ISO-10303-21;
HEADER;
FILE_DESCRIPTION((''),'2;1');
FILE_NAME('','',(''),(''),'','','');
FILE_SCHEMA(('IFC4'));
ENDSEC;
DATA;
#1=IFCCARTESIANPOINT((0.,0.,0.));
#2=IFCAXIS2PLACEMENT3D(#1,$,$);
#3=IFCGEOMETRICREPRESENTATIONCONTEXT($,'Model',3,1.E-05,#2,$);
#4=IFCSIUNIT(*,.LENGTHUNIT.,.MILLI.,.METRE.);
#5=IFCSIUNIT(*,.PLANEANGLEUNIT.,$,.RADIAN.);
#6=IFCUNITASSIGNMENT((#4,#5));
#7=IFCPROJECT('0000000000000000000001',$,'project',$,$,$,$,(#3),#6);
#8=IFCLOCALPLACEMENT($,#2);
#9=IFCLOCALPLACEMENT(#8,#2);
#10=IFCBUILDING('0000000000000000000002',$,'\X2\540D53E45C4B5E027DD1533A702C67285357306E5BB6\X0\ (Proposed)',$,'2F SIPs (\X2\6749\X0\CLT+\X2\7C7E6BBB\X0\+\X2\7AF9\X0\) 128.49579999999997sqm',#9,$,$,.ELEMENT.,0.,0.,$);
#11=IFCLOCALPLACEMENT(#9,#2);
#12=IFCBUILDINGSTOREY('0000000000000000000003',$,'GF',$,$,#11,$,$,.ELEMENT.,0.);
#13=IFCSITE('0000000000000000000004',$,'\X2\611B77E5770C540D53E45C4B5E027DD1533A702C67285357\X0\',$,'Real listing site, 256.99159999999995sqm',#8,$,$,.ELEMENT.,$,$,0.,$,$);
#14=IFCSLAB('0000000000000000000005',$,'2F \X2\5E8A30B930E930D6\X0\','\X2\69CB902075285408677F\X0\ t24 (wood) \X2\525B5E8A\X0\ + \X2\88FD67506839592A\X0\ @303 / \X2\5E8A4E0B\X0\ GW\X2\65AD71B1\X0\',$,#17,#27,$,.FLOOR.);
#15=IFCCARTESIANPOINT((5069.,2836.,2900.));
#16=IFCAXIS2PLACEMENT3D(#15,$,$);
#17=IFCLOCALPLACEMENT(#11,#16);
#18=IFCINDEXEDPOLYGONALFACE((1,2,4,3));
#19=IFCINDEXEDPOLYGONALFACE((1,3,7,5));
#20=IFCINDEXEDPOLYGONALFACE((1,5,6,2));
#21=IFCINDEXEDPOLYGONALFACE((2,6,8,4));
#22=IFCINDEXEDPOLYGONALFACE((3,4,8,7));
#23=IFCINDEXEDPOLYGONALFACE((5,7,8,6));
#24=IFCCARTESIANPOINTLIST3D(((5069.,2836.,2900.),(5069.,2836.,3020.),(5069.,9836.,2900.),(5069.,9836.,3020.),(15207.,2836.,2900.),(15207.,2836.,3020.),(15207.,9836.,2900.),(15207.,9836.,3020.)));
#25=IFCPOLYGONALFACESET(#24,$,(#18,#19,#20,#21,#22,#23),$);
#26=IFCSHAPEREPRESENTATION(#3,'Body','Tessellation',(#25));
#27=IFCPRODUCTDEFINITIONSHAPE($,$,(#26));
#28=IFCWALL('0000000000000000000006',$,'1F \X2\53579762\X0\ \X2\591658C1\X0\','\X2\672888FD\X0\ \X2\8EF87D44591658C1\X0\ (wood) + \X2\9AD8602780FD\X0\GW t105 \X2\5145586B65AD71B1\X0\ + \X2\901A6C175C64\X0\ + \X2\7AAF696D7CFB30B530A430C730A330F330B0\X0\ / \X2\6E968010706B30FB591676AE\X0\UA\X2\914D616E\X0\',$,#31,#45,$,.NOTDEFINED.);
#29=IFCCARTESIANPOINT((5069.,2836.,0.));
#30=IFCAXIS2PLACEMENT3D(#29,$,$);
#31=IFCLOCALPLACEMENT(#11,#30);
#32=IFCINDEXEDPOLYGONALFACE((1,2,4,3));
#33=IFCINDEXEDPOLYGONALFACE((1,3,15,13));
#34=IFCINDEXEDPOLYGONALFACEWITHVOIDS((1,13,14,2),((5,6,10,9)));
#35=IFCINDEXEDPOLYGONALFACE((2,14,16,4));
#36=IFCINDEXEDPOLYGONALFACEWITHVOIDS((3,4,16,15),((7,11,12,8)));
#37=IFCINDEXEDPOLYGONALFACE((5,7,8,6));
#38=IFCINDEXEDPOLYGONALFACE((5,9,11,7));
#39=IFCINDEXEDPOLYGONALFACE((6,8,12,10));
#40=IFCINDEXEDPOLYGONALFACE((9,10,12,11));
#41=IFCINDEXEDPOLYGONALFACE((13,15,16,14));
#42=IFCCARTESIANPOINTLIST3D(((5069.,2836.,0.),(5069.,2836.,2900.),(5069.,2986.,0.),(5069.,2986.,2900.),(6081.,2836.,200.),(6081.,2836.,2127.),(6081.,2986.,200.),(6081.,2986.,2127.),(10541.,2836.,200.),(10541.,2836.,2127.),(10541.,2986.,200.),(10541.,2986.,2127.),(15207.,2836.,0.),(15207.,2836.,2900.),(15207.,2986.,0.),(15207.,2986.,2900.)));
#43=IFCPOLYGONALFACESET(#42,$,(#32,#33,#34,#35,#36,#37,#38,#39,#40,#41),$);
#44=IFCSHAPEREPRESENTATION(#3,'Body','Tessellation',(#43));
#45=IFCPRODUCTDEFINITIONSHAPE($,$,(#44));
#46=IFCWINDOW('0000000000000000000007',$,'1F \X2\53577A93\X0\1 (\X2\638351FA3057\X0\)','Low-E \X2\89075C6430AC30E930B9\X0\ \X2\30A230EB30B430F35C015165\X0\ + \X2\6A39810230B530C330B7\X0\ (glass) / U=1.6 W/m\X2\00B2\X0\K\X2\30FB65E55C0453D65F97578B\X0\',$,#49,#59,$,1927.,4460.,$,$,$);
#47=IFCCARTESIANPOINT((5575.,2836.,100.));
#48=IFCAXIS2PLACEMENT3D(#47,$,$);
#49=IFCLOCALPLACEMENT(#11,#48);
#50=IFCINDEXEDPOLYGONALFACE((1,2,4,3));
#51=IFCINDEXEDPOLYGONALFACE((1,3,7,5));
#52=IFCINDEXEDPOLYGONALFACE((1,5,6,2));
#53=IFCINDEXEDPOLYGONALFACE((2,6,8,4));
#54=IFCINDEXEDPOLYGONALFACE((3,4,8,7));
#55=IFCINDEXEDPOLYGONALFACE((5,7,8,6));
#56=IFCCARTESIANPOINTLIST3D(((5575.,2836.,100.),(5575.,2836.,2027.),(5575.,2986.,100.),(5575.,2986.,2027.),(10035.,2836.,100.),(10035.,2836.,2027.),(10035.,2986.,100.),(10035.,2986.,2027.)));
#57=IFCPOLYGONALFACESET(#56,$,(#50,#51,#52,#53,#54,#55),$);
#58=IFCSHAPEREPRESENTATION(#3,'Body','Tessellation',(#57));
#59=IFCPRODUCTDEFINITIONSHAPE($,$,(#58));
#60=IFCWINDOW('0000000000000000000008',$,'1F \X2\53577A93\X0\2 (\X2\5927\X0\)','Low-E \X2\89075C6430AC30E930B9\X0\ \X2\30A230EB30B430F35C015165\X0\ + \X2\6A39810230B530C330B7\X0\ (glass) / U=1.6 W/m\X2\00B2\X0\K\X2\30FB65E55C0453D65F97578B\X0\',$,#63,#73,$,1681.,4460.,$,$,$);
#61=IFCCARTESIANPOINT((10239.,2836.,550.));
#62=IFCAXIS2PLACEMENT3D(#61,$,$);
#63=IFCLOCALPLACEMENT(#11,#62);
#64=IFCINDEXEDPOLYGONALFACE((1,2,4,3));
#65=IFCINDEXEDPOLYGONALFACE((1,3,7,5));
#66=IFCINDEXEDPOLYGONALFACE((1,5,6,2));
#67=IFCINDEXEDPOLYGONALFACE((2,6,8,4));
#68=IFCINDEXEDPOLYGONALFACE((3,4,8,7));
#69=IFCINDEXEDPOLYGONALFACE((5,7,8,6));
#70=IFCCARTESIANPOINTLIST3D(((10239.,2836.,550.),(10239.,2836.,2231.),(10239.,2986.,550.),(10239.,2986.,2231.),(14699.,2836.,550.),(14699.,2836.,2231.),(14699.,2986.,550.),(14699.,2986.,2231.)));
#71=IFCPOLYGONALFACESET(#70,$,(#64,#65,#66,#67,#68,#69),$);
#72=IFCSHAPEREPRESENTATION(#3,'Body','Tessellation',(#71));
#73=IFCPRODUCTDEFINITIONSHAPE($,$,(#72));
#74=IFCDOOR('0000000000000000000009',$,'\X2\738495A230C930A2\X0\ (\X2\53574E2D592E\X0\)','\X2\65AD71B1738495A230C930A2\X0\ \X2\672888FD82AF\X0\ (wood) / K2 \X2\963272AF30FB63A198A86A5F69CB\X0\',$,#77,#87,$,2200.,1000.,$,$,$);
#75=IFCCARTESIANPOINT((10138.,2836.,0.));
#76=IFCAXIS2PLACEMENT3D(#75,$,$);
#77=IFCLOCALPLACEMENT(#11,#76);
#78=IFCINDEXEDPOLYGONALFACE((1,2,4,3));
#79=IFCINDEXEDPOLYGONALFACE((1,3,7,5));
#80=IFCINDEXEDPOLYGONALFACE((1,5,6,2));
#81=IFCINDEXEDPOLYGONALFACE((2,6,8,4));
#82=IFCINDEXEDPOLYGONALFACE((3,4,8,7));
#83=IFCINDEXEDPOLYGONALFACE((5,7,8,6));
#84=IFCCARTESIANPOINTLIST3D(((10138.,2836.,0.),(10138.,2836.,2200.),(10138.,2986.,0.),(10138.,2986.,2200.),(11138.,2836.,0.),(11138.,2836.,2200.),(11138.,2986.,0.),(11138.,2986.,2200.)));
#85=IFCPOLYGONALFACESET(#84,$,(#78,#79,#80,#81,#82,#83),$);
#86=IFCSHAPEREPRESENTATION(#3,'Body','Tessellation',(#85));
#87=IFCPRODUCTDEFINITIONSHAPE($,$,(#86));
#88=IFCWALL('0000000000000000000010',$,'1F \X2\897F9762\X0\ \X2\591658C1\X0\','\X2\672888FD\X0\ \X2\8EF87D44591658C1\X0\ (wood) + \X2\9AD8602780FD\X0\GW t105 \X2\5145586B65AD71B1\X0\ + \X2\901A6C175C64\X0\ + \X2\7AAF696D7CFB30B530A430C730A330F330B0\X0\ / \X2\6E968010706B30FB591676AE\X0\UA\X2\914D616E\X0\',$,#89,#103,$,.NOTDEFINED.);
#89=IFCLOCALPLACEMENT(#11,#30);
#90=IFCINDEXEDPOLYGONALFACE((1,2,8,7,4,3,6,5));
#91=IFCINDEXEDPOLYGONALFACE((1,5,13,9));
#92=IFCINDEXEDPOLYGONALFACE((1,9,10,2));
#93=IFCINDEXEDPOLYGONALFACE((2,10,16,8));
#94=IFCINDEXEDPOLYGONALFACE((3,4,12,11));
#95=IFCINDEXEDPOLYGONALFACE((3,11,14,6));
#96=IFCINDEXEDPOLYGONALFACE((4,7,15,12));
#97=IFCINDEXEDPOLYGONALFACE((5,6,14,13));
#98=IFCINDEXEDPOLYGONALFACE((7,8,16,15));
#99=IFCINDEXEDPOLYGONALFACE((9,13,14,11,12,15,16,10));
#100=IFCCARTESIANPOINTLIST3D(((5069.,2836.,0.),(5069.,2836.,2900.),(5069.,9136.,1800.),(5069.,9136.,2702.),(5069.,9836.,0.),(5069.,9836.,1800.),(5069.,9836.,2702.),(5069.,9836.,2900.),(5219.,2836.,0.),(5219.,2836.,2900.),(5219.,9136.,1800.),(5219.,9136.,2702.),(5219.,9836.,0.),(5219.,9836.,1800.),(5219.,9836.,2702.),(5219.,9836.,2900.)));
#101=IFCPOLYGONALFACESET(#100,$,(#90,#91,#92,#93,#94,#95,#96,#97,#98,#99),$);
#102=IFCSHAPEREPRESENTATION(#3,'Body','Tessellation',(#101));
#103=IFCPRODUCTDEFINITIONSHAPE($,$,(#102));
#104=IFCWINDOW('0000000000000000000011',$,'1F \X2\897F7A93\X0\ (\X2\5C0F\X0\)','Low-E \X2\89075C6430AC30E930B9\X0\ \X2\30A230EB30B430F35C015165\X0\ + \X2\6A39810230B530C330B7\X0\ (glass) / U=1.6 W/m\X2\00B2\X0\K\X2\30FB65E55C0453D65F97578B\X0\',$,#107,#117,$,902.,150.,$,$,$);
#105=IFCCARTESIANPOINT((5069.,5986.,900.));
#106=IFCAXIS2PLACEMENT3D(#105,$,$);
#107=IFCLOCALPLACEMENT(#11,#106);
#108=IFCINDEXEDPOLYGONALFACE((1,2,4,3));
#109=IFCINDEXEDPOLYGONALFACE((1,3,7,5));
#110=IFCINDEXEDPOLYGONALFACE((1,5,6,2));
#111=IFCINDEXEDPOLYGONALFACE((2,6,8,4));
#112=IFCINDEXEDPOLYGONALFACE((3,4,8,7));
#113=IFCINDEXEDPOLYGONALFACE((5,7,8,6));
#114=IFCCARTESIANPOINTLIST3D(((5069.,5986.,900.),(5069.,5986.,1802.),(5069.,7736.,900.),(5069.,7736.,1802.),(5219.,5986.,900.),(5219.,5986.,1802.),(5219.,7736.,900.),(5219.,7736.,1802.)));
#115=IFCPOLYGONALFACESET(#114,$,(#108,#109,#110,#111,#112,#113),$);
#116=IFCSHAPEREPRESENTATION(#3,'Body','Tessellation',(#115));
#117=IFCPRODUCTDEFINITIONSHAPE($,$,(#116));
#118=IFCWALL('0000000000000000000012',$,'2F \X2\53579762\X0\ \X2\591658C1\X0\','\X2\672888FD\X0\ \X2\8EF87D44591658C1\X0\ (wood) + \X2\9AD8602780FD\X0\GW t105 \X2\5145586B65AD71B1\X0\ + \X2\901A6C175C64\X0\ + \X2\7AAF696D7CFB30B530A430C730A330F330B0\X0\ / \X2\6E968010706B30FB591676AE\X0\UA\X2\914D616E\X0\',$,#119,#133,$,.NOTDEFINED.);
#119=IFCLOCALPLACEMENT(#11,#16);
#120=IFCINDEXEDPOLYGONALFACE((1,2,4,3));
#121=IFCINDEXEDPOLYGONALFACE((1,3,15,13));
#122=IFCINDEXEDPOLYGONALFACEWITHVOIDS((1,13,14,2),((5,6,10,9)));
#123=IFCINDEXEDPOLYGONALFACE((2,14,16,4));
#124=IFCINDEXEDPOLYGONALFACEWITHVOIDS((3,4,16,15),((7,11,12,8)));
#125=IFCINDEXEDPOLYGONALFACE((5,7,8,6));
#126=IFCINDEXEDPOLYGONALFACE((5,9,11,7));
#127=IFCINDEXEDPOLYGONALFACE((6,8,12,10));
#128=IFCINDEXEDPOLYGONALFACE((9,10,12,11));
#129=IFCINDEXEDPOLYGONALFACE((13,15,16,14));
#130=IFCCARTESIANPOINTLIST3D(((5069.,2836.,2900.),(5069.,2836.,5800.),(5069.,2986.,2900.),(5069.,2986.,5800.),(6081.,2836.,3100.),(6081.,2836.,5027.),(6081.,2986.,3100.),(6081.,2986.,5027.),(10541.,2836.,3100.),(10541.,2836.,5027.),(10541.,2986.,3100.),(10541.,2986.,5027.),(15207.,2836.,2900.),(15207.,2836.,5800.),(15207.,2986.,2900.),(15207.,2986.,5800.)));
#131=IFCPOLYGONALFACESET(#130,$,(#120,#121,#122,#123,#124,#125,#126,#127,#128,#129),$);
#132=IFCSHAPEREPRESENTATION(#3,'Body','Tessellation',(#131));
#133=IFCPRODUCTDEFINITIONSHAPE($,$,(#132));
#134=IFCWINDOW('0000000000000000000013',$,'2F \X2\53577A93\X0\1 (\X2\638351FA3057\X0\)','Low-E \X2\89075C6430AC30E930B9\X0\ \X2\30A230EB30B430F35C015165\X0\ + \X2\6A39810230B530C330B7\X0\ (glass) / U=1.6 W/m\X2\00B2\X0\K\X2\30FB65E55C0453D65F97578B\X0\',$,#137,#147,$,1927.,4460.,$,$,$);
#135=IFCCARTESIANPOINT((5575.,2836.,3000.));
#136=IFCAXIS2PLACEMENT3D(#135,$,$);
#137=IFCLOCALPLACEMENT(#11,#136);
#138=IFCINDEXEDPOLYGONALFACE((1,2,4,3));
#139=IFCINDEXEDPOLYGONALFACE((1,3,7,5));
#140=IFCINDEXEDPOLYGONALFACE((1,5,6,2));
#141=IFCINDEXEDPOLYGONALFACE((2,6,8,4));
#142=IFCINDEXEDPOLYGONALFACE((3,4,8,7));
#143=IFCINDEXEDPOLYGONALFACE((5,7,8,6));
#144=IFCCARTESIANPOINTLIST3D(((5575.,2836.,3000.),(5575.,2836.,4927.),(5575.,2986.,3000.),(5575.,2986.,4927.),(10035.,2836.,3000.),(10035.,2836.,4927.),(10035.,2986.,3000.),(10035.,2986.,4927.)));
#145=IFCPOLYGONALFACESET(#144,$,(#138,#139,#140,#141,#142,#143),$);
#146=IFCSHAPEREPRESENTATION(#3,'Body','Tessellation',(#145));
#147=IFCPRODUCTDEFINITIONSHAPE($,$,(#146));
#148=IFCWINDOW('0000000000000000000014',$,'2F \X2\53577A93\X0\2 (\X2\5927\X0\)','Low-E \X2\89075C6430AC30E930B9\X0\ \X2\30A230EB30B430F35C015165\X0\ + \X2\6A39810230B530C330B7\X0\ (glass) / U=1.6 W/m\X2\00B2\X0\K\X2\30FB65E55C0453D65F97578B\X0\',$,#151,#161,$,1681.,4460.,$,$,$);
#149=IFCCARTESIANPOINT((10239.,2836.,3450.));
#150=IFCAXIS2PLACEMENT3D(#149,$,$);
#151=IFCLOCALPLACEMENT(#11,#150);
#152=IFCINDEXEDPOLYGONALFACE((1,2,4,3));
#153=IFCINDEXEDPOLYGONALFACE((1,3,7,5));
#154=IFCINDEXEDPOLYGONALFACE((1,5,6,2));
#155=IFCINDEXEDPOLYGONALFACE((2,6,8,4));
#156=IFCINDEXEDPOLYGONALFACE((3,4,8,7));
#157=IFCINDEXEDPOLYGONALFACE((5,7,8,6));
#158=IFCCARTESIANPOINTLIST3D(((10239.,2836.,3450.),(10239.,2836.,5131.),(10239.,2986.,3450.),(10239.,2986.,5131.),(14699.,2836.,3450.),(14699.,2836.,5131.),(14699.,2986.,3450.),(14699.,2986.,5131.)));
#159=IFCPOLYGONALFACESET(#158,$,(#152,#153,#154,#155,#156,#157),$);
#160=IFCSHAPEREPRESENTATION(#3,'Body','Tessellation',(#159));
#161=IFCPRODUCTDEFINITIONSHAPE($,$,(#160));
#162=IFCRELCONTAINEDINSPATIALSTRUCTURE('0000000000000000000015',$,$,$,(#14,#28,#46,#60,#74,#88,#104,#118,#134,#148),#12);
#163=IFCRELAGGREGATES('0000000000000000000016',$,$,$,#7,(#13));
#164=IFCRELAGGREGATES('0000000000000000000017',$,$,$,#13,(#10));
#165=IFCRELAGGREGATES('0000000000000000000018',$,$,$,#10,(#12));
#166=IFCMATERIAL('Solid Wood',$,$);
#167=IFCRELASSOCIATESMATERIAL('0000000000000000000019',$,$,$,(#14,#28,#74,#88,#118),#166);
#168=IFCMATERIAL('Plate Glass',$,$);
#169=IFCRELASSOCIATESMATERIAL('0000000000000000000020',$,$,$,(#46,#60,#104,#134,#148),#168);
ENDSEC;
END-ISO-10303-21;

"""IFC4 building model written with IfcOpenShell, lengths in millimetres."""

from ifc_helpers import new_model, si_unit, frame, frame_2d, origin, place, context, project, spatial, rectangle, extrude, material, element, fill, save


model = new_model("IFC4")

# Units and contexts
model_context = context("Model", 3, precision=1e-05, world=origin())
ifc_project = project(units=[si_unit("LENGTHUNIT", "METRE", prefix="MILLI"), si_unit("PLANEANGLEUNIT", "RADIAN")], contexts=[model_context])

# Site, building, storey
site_placement = place(None, origin())
site = spatial("IfcSite", under=ifc_project, at=site_placement, Name="愛知県名古屋市緑区瀬木南", ObjectType="Real listing site, 256.99159999999995sqm", CompositionType="ELEMENT", RefElevation=0.0)
building_placement = place(site_placement, origin())
building = spatial("IfcBuilding", under=site, at=building_placement, Name="名古屋市緑区瀬木南の家 (Proposed)", ObjectType="2F SIPs (杉CLT+籾殻+竹) 128.49579999999997sqm", CompositionType="ELEMENT", ElevationOfRefHeight=0.0, ElevationOfTerrain=0.0)
storey_placement = place(building_placement, origin())
storey = spatial("IfcBuildingStorey", under=building, at=storey_placement, Name="GF", CompositionType="ELEMENT", Elevation=0.0)

# Slab
ifc_material_1 = material(Name="Solid Wood")
slab_1_placement = place(storey_placement, frame((5069.0, 2836.0, 2900.0)))
element("IfcSlab", 1, at=slab_1_placement, inside=storey, material=ifc_material_1, Name="2F 床スラブ", Description="構造用合板 t24 (wood) 剛床 + 製材根太 @303 / 床下 GW断熱", PredefinedType="FLOOR", context=model_context, shape_type="SweptSolid", body=[
    extrude(rectangle(XDim=10138.0, YDim=7000.0, at=frame_2d((5069.0, 3500.0))), frame((5069.0, 2836.0, 2900.0)), (0.0, 0.0, 1.0), 120.0),
])

# Wall, openings, windows, door
wall_1_placement = place(storey_placement, frame((5069.0, 2836.0, 0.0)))
wall_1 = element("IfcWall", 2, at=wall_1_placement, inside=storey, material=ifc_material_1, Name="1F 南面 外壁", Description="木製 軸組外壁 (wood) + 高性能GW t105 充填断熱 + 通気層 + 窯業系サイディング / 準耐火・外皮UA配慮", PredefinedType="NOTDEFINED", context=model_context, shape_type="SweptSolid", body=[
    extrude(rectangle(XDim=10138.0, YDim=150.0, at=frame_2d((5069.0, 75.0))), frame((5069.0, 2836.0, 0.0)), (0.0, 0.0, 1.0), 2900.0),
])
opening_1_placement = place(storey_placement, frame((5575.0, 2836.0, 100.0)))
opening_1 = element("IfcOpeningElement", 3, at=opening_1_placement, cuts=wall_1, PredefinedType="NOTDEFINED", context=model_context, shape_type="SweptSolid", body=[
    extrude(rectangle(XDim=4460.0, YDim=150.0, at=frame_2d((2230.0, 75.0))), frame((5575.0, 2836.0, 100.0)), (0.0, 0.0, 1.0), 1927.0),
])
opening_2_placement = place(storey_placement, frame((10239.0, 2836.0, 550.0)))
opening_2 = element("IfcOpeningElement", 4, at=opening_2_placement, cuts=wall_1, PredefinedType="NOTDEFINED", context=model_context, shape_type="SweptSolid", body=[
    extrude(rectangle(XDim=4460.0, YDim=150.0, at=frame_2d((2230.0, 75.0))), frame((10239.0, 2836.0, 550.0)), (0.0, 0.0, 1.0), 1681.0),
])
opening_3_placement = place(storey_placement, frame((10138.0, 2836.0, 0.0)))
opening_3 = element("IfcOpeningElement", 5, at=opening_3_placement, cuts=wall_1, PredefinedType="NOTDEFINED", context=model_context, shape_type="SweptSolid", body=[
    extrude(rectangle(XDim=1000.0, YDim=150.0, at=frame_2d((500.0, 75.0))), frame((10138.0, 2836.0, 0.0)), (0.0, 0.0, 1.0), 2200.0),
])
ifc_material_2 = material(Name="Plate Glass")
window_1_placement = place(storey_placement, frame((5575.0, 2836.0, 100.0)))
window_1 = element("IfcWindow", 6, at=window_1_placement, inside=storey, material=ifc_material_2, Name="1F 南窓1 (掃出し)", Description="Low-E 複層ガラス アルゴン封入 + 樹脂サッシ (glass) / U=1.6 W/m²K・日射取得型", OverallHeight=1927.0, OverallWidth=4460.0, context=model_context, shape_type="SweptSolid", body=[
    extrude(rectangle(XDim=4460.0, YDim=150.0, at=frame_2d((2230.0, 75.0))), frame((5575.0, 2836.0, 100.0)), (0.0, 0.0, 1.0), 1927.0),
])
fill(opening_1, window_1)
window_2_placement = place(storey_placement, frame((10239.0, 2836.0, 550.0)))
window_2 = element("IfcWindow", 7, at=window_2_placement, inside=storey, material=ifc_material_2, Name="1F 南窓2 (大)", Description="Low-E 複層ガラス アルゴン封入 + 樹脂サッシ (glass) / U=1.6 W/m²K・日射取得型", OverallHeight=1681.0, OverallWidth=4460.0, context=model_context, shape_type="SweptSolid", body=[
    extrude(rectangle(XDim=4460.0, YDim=150.0, at=frame_2d((2230.0, 75.0))), frame((10239.0, 2836.0, 550.0)), (0.0, 0.0, 1.0), 1681.0),
])
fill(opening_2, window_2)
door_placement = place(storey_placement, frame((10138.0, 2836.0, 0.0)))
door = element("IfcDoor", 8, at=door_placement, inside=storey, material=ifc_material_1, Name="玄関ドア (南中央)", Description="断熱玄関ドア 木製芯 (wood) / K2 防犯・採風機構", OverallHeight=2200.0, OverallWidth=1000.0, context=model_context, shape_type="SweptSolid", body=[
    extrude(rectangle(XDim=1000.0, YDim=150.0, at=frame_2d((500.0, 75.0))), frame((10138.0, 2836.0, 0.0)), (0.0, 0.0, 1.0), 2200.0),
])
fill(opening_3, door)

# Wall, opening, window
wall_2_placement = place(storey_placement, frame((5069.0, 2836.0, 0.0)))
wall_2 = element("IfcWall", 9, at=wall_2_placement, inside=storey, material=ifc_material_1, Name="1F 西面 外壁", Description="木製 軸組外壁 (wood) + 高性能GW t105 充填断熱 + 通気層 + 窯業系サイディング / 準耐火・外皮UA配慮", PredefinedType="NOTDEFINED", context=model_context, shape_type="SweptSolid", body=[
    extrude(rectangle(XDim=150.0, YDim=7000.0, at=frame_2d((75.0, 3500.0))), frame((5069.0, 2836.0, 0.0)), (0.0, 0.0, 1.0), 2900.0),
])
opening_4_placement = place(storey_placement, frame((5069.0, 5986.0, 900.0)))
opening_4 = element("IfcOpeningElement", 10, at=opening_4_placement, cuts=wall_2, PredefinedType="NOTDEFINED", context=model_context, shape_type="SweptSolid", body=[
    extrude(rectangle(XDim=150.0, YDim=1750.0, at=frame_2d((75.0, 875.0))), frame((5069.0, 5986.0, 900.0)), (0.0, 0.0, 1.0), 902.0),
])
window_3_placement = place(storey_placement, frame((5069.0, 5986.0, 900.0)))
window_3 = element("IfcWindow", 11, at=window_3_placement, inside=storey, material=ifc_material_2, Name="1F 西窓 (小)", Description="Low-E 複層ガラス アルゴン封入 + 樹脂サッシ (glass) / U=1.6 W/m²K・日射取得型", OverallHeight=902.0, OverallWidth=150.0, context=model_context, shape_type="SweptSolid", body=[
    extrude(rectangle(XDim=150.0, YDim=1750.0, at=frame_2d((75.0, 875.0))), frame((5069.0, 5986.0, 900.0)), (0.0, 0.0, 1.0), 902.0),
])
fill(opening_4, window_3)

# Wall, openings, windows
wall_3_placement = place(storey_placement, frame((5069.0, 2836.0, 2900.0)))
wall_3 = element("IfcWall", 12, at=wall_3_placement, inside=storey, material=ifc_material_1, Name="2F 南面 外壁", Description="木製 軸組外壁 (wood) + 高性能GW t105 充填断熱 + 通気層 + 窯業系サイディング / 準耐火・外皮UA配慮", PredefinedType="NOTDEFINED", context=model_context, shape_type="SweptSolid", body=[
    extrude(rectangle(XDim=10138.0, YDim=150.0, at=frame_2d((5069.0, 75.0))), frame((5069.0, 2836.0, 2900.0)), (0.0, 0.0, 1.0), 2900.0),
])
opening_5_placement = place(storey_placement, frame((5575.0, 2836.0, 3000.0)))
opening_5 = element("IfcOpeningElement", 13, at=opening_5_placement, cuts=wall_3, PredefinedType="NOTDEFINED", context=model_context, shape_type="SweptSolid", body=[
    extrude(rectangle(XDim=4460.0, YDim=150.0, at=frame_2d((2230.0, 75.0))), frame((5575.0, 2836.0, 3000.0)), (0.0, 0.0, 1.0), 1927.0),
])
opening_6_placement = place(storey_placement, frame((10239.0, 2836.0, 3450.0)))
opening_6 = element("IfcOpeningElement", 14, at=opening_6_placement, cuts=wall_3, PredefinedType="NOTDEFINED", context=model_context, shape_type="SweptSolid", body=[
    extrude(rectangle(XDim=4460.0, YDim=150.0, at=frame_2d((2230.0, 75.0))), frame((10239.0, 2836.0, 3450.0)), (0.0, 0.0, 1.0), 1681.0),
])
window_4_placement = place(storey_placement, frame((5575.0, 2836.0, 3000.0)))
window_4 = element("IfcWindow", 15, at=window_4_placement, inside=storey, material=ifc_material_2, Name="2F 南窓1 (掃出し)", Description="Low-E 複層ガラス アルゴン封入 + 樹脂サッシ (glass) / U=1.6 W/m²K・日射取得型", OverallHeight=1927.0, OverallWidth=4460.0, context=model_context, shape_type="SweptSolid", body=[
    extrude(rectangle(XDim=4460.0, YDim=150.0, at=frame_2d((2230.0, 75.0))), frame((5575.0, 2836.0, 3000.0)), (0.0, 0.0, 1.0), 1927.0),
])
fill(opening_5, window_4)
window_5_placement = place(storey_placement, frame((10239.0, 2836.0, 3450.0)))
window_5 = element("IfcWindow", 16, at=window_5_placement, inside=storey, material=ifc_material_2, Name="2F 南窓2 (大)", Description="Low-E 複層ガラス アルゴン封入 + 樹脂サッシ (glass) / U=1.6 W/m²K・日射取得型", OverallHeight=1681.0, OverallWidth=4460.0, context=model_context, shape_type="SweptSolid", body=[
    extrude(rectangle(XDim=4460.0, YDim=150.0, at=frame_2d((2230.0, 75.0))), frame((10239.0, 2836.0, 3450.0)), (0.0, 0.0, 1.0), 1681.0),
])
fill(opening_6, window_5)

save(model, "model.ifc")
